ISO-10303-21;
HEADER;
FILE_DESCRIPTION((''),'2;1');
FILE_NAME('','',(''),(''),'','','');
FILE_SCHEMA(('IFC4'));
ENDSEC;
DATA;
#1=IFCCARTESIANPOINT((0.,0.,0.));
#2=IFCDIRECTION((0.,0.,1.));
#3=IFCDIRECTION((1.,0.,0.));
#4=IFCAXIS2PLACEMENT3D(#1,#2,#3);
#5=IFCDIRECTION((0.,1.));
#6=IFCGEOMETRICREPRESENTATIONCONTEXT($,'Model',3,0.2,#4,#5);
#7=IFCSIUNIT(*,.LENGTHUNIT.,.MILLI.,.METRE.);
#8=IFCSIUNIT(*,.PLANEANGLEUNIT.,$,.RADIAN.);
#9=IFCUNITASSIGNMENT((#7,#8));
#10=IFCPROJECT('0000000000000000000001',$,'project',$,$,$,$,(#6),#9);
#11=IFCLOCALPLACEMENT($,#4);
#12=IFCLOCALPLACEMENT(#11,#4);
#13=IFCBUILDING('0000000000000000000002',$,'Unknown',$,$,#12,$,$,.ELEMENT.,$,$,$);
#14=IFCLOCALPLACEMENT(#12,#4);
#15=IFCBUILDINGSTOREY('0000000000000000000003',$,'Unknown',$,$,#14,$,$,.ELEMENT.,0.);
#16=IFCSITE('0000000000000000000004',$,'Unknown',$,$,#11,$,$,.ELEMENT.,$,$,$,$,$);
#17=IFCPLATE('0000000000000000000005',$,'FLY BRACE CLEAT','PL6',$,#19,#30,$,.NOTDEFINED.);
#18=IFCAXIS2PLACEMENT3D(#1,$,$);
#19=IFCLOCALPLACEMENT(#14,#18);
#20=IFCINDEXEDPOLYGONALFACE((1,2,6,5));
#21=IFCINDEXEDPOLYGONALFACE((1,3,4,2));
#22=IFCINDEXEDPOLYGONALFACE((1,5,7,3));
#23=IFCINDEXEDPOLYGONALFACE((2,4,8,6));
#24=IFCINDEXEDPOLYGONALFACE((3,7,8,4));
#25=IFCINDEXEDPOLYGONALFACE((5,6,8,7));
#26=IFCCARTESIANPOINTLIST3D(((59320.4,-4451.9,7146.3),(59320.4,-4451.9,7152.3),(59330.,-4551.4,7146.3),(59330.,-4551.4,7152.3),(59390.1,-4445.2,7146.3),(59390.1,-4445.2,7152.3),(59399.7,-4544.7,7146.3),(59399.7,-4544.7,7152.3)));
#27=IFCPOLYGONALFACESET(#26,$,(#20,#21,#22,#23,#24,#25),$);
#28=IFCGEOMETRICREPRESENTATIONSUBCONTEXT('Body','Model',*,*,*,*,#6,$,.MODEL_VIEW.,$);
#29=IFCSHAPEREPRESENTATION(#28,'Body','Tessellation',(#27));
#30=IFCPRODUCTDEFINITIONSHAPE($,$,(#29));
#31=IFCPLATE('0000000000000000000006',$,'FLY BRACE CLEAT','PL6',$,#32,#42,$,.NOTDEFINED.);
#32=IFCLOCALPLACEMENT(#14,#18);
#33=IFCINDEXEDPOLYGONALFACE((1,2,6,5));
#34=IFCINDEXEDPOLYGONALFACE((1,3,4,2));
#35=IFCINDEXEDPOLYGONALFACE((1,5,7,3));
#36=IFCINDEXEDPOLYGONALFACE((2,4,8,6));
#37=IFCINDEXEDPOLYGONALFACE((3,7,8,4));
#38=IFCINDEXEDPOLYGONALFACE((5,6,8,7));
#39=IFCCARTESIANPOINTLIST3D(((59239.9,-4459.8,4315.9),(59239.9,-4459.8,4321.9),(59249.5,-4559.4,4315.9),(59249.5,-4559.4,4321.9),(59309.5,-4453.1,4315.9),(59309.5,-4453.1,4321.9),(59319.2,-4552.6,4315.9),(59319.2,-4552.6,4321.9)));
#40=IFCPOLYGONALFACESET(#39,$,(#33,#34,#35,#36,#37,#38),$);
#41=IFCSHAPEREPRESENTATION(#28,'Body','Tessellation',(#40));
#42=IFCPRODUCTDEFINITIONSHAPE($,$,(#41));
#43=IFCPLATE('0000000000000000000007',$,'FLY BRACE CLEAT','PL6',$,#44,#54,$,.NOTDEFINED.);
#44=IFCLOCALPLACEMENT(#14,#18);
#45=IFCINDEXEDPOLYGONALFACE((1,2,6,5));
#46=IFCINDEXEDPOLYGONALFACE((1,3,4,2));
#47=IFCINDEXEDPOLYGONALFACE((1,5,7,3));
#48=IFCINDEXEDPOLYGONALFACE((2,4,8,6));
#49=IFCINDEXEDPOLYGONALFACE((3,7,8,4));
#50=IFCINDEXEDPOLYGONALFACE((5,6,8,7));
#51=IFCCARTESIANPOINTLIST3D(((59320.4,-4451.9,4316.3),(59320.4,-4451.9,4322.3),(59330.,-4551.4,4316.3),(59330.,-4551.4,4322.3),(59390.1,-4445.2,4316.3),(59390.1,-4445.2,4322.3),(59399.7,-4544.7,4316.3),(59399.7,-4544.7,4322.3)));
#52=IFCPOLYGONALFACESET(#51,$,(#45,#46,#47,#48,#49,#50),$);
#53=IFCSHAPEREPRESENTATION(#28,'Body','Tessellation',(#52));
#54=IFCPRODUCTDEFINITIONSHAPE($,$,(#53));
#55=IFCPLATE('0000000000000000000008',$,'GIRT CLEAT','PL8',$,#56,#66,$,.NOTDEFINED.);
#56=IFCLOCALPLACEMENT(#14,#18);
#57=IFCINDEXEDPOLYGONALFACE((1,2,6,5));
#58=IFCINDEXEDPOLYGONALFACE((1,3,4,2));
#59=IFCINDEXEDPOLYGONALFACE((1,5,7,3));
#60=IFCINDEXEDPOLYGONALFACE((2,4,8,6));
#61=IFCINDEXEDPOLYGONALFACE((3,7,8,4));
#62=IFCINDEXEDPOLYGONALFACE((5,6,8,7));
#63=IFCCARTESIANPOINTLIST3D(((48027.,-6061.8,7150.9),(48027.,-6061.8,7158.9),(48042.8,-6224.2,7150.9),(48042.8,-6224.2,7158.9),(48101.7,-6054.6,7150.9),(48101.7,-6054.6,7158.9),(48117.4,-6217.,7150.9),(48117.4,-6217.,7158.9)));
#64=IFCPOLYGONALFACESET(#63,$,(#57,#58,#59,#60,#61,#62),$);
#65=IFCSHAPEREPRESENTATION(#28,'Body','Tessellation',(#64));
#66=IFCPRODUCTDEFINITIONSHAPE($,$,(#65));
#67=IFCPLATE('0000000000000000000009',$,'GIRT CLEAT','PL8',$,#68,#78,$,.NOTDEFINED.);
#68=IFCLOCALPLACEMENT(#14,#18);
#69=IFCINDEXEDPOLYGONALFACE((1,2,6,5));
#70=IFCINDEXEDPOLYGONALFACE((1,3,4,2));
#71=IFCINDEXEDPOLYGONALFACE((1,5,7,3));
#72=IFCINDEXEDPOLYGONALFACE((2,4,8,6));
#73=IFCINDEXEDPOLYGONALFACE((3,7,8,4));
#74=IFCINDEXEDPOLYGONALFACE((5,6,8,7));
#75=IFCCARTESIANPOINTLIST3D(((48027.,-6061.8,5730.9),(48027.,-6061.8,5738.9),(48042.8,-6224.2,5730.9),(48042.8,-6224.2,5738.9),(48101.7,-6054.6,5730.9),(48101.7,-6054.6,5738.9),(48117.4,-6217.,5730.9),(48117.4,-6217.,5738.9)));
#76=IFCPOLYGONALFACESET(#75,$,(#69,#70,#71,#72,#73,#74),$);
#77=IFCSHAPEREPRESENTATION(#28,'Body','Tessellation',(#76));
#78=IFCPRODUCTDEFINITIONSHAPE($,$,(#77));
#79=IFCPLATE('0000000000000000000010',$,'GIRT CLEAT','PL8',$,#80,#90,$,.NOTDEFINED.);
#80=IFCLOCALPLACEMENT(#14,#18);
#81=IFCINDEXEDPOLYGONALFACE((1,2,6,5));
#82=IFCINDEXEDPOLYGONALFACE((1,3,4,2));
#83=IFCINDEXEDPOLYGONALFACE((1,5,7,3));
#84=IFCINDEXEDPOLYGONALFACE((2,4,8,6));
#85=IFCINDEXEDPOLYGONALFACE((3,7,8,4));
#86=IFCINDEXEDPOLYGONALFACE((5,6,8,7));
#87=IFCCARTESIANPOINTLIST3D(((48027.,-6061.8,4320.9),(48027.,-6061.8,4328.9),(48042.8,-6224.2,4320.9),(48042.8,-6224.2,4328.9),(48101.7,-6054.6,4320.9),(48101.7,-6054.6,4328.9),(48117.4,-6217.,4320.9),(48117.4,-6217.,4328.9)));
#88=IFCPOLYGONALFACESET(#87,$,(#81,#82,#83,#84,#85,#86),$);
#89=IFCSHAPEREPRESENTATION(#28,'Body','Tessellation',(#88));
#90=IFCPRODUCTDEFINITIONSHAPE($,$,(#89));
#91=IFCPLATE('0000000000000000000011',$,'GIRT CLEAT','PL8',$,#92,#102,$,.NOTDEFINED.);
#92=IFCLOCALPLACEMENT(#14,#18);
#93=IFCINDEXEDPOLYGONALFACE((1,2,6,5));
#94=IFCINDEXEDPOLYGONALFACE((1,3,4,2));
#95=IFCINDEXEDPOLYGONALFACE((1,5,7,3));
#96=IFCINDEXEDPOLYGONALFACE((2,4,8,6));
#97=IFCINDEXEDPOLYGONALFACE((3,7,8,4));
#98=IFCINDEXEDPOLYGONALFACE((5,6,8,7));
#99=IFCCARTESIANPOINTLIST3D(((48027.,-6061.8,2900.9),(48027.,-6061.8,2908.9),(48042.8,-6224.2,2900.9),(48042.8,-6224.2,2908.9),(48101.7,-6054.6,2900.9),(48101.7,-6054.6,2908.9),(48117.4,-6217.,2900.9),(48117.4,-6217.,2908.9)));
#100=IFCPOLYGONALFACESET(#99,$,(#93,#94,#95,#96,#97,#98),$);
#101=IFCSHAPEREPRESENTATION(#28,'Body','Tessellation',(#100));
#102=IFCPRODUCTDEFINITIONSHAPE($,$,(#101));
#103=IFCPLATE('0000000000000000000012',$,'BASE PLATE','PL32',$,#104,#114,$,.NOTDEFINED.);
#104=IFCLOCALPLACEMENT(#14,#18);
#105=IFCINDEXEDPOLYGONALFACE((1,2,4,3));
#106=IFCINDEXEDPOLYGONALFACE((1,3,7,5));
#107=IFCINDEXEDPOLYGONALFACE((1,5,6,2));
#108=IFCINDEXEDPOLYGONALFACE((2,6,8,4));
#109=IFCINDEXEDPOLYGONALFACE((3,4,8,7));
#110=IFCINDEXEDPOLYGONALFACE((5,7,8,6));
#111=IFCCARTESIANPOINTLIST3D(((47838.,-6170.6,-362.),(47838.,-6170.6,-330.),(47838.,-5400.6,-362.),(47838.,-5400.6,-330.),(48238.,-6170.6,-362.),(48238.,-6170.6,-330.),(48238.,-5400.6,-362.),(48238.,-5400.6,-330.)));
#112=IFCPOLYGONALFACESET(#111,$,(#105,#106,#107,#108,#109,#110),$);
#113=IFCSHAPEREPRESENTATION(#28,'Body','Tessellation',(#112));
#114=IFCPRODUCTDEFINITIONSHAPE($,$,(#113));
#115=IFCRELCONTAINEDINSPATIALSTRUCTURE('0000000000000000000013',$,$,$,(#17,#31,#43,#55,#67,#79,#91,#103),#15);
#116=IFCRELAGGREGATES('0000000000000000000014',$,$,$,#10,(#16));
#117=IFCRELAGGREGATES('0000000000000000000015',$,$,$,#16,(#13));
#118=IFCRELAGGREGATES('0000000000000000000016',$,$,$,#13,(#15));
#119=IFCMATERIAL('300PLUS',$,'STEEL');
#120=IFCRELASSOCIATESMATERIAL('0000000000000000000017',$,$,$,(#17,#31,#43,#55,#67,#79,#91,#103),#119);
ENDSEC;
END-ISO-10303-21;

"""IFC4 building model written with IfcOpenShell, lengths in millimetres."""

from ifc_helpers import new_model, si_unit, direction, frame, origin_with_axes, place, context, subcontext, project, spatial, line, indexed_curve, outline, extrude, material, element, save


model = new_model("IFC4")

# Units and contexts
model_context = context("Model", 3, precision=0.2, world=origin_with_axes(), true_north=direction((0.0, 1.0)))
body_context = subcontext(model_context, "Body", "Model", "MODEL_VIEW")
ifc_project = project(units=[si_unit("LENGTHUNIT", "METRE", prefix="MILLI"), si_unit("PLANEANGLEUNIT", "RADIAN")], contexts=[model_context])

# Site, building, storey
site_placement = place(None, origin_with_axes())
site = spatial("IfcSite", under=ifc_project, at=site_placement, Name="Unknown", CompositionType="ELEMENT")
building_placement = place(site_placement, origin_with_axes())
building = spatial("IfcBuilding", under=site, at=building_placement, Name="Unknown", CompositionType="ELEMENT")
storey_placement = place(building_placement, origin_with_axes())
storey = spatial("IfcBuildingStorey", under=building, at=storey_placement, Name="Unknown", CompositionType="ELEMENT", Elevation=0.0)

# Shared definitions
ifc_material_1 = material(Name="300PLUS", Category="STEEL")

# Plates
plate_1_placement = place(storey_placement, frame((59330.0, -4551.4, 7149.3), z_axis=(0.0, 0.0, 1.0), x_axis=(0.995412, 0.095685, 0.0)))
element("IfcPlate", 1, at=plate_1_placement, inside=storey, material=ifc_material_1, Name="FLY BRACE CLEAT", Description="PL6", PredefinedType="NOTDEFINED", context=body_context, shape_type="SolidModel", body=[
    extrude(outline(indexed_curve([(0.0, 0.0), (70.0, 0.0), (70.0, 100.0), (0.0, 100.0)], segments=[line(1, 2, 3, 4, 1)])), frame((0.0, 0.0, 3.0), z_axis=(0.0, 0.0, 1.0), x_axis=(1.0, 0.0, 0.0)), (0.0, 0.0, -1.0), 6.0),
])
plate_2_placement = place(storey_placement, frame((59309.5, -4453.1, 4318.9), z_axis=(0.0, 0.0, 1.0), x_axis=(-0.995399, -0.095821, 0.0)))
element("IfcPlate", 2, at=plate_2_placement, inside=storey, material=ifc_material_1, Name="FLY BRACE CLEAT", Description="PL6", PredefinedType="NOTDEFINED", context=body_context, shape_type="SolidModel", body=[
    extrude(outline(indexed_curve([(0.0, 0.0), (69.9, 0.0), (69.9, 100.1), (-0.1, 100.0)], segments=[line(1, 2, 3, 4, 1)])), frame((0.0, 0.0, 3.0), z_axis=(0.0, 0.0, 1.0), x_axis=(1.0, 0.0, 0.0)), (0.0, 0.0, -1.0), 6.0),
])
plate_3_placement = place(storey_placement, frame((59330.0, -4551.4, 4319.3), z_axis=(0.0, 0.0, 1.0), x_axis=(0.995412, 0.095685, 0.0)))
element("IfcPlate", 3, at=plate_3_placement, inside=storey, material=ifc_material_1, Name="FLY BRACE CLEAT", Description="PL6", PredefinedType="NOTDEFINED", context=body_context, shape_type="SolidModel", body=[
    extrude(outline(indexed_curve([(0.0, 0.0), (70.0, 0.0), (70.0, 100.0), (0.0, 100.0)], segments=[line(1, 2, 3, 4, 1)])), frame((0.0, 0.0, 3.0), z_axis=(0.0, 0.0, 1.0), x_axis=(1.0, 0.0, 0.0)), (0.0, 0.0, -1.0), 6.0),
])
for number, where, z_axis, x_axis, name in (
    (4, (48042.8, -6224.2, 7154.9), (0.0, 0.0, 1.0), (0.995375, 0.096068, 0.0), "GIRT CLEAT"),
    (5, (48042.8, -6224.2, 5734.9), (0.0, 0.0, 1.0), (0.995375, 0.096068, 0.0), "GIRT CLEAT"),
    (6, (48042.8, -6224.2, 4324.9), (0.0, 0.0, 1.0), (0.995375, 0.096068, 0.0), "GIRT CLEAT"),
    (7, (48042.8, -6224.2, 2904.9), (0.0, 0.0, 1.0), (0.995375, 0.096068, 0.0), "GIRT CLEAT"),
):
    element("IfcPlate", number, at=place(storey_placement, frame(where, z_axis=z_axis, x_axis=x_axis)), inside=storey, material=ifc_material_1, Name=name, Description="PL8", PredefinedType="NOTDEFINED", context=body_context, shape_type="SolidModel", body=[
        extrude(outline(indexed_curve([(0.0, 0.0), (74.9, 0.0), (74.9, 163.2), (-0.1, 163.2)], segments=[line(1, 2, 3, 4, 1)])), frame((0.0, 0.0, 4.0), z_axis=(0.0, 0.0, 1.0), x_axis=(1.0, 0.0, 0.0)), (0.0, 0.0, -1.0), 8.0),
    ])
plate_4_placement = place(storey_placement, frame((48238.0, -6170.6, -346.0), z_axis=(0.0, 0.0, 1.0), x_axis=(0.0, 1.0, 0.0)))
element("IfcPlate", 8, at=plate_4_placement, inside=storey, material=ifc_material_1, Name="BASE PLATE", Description="PL32", PredefinedType="NOTDEFINED", context=body_context, shape_type="SolidModel", body=[
    extrude(outline(indexed_curve([(0.0, 0.0), (770.0, 0.0), (770.0, 400.0), (0.0, 400.0)], segments=[line(1, 2, 3, 4, 1)])), frame((0.0, 0.0, 16.0), z_axis=(0.0, 0.0, 1.0), x_axis=(1.0, 0.0, 0.0)), (0.0, 0.0, -1.0), 32.0),
])

save(model, "model.ifc")
